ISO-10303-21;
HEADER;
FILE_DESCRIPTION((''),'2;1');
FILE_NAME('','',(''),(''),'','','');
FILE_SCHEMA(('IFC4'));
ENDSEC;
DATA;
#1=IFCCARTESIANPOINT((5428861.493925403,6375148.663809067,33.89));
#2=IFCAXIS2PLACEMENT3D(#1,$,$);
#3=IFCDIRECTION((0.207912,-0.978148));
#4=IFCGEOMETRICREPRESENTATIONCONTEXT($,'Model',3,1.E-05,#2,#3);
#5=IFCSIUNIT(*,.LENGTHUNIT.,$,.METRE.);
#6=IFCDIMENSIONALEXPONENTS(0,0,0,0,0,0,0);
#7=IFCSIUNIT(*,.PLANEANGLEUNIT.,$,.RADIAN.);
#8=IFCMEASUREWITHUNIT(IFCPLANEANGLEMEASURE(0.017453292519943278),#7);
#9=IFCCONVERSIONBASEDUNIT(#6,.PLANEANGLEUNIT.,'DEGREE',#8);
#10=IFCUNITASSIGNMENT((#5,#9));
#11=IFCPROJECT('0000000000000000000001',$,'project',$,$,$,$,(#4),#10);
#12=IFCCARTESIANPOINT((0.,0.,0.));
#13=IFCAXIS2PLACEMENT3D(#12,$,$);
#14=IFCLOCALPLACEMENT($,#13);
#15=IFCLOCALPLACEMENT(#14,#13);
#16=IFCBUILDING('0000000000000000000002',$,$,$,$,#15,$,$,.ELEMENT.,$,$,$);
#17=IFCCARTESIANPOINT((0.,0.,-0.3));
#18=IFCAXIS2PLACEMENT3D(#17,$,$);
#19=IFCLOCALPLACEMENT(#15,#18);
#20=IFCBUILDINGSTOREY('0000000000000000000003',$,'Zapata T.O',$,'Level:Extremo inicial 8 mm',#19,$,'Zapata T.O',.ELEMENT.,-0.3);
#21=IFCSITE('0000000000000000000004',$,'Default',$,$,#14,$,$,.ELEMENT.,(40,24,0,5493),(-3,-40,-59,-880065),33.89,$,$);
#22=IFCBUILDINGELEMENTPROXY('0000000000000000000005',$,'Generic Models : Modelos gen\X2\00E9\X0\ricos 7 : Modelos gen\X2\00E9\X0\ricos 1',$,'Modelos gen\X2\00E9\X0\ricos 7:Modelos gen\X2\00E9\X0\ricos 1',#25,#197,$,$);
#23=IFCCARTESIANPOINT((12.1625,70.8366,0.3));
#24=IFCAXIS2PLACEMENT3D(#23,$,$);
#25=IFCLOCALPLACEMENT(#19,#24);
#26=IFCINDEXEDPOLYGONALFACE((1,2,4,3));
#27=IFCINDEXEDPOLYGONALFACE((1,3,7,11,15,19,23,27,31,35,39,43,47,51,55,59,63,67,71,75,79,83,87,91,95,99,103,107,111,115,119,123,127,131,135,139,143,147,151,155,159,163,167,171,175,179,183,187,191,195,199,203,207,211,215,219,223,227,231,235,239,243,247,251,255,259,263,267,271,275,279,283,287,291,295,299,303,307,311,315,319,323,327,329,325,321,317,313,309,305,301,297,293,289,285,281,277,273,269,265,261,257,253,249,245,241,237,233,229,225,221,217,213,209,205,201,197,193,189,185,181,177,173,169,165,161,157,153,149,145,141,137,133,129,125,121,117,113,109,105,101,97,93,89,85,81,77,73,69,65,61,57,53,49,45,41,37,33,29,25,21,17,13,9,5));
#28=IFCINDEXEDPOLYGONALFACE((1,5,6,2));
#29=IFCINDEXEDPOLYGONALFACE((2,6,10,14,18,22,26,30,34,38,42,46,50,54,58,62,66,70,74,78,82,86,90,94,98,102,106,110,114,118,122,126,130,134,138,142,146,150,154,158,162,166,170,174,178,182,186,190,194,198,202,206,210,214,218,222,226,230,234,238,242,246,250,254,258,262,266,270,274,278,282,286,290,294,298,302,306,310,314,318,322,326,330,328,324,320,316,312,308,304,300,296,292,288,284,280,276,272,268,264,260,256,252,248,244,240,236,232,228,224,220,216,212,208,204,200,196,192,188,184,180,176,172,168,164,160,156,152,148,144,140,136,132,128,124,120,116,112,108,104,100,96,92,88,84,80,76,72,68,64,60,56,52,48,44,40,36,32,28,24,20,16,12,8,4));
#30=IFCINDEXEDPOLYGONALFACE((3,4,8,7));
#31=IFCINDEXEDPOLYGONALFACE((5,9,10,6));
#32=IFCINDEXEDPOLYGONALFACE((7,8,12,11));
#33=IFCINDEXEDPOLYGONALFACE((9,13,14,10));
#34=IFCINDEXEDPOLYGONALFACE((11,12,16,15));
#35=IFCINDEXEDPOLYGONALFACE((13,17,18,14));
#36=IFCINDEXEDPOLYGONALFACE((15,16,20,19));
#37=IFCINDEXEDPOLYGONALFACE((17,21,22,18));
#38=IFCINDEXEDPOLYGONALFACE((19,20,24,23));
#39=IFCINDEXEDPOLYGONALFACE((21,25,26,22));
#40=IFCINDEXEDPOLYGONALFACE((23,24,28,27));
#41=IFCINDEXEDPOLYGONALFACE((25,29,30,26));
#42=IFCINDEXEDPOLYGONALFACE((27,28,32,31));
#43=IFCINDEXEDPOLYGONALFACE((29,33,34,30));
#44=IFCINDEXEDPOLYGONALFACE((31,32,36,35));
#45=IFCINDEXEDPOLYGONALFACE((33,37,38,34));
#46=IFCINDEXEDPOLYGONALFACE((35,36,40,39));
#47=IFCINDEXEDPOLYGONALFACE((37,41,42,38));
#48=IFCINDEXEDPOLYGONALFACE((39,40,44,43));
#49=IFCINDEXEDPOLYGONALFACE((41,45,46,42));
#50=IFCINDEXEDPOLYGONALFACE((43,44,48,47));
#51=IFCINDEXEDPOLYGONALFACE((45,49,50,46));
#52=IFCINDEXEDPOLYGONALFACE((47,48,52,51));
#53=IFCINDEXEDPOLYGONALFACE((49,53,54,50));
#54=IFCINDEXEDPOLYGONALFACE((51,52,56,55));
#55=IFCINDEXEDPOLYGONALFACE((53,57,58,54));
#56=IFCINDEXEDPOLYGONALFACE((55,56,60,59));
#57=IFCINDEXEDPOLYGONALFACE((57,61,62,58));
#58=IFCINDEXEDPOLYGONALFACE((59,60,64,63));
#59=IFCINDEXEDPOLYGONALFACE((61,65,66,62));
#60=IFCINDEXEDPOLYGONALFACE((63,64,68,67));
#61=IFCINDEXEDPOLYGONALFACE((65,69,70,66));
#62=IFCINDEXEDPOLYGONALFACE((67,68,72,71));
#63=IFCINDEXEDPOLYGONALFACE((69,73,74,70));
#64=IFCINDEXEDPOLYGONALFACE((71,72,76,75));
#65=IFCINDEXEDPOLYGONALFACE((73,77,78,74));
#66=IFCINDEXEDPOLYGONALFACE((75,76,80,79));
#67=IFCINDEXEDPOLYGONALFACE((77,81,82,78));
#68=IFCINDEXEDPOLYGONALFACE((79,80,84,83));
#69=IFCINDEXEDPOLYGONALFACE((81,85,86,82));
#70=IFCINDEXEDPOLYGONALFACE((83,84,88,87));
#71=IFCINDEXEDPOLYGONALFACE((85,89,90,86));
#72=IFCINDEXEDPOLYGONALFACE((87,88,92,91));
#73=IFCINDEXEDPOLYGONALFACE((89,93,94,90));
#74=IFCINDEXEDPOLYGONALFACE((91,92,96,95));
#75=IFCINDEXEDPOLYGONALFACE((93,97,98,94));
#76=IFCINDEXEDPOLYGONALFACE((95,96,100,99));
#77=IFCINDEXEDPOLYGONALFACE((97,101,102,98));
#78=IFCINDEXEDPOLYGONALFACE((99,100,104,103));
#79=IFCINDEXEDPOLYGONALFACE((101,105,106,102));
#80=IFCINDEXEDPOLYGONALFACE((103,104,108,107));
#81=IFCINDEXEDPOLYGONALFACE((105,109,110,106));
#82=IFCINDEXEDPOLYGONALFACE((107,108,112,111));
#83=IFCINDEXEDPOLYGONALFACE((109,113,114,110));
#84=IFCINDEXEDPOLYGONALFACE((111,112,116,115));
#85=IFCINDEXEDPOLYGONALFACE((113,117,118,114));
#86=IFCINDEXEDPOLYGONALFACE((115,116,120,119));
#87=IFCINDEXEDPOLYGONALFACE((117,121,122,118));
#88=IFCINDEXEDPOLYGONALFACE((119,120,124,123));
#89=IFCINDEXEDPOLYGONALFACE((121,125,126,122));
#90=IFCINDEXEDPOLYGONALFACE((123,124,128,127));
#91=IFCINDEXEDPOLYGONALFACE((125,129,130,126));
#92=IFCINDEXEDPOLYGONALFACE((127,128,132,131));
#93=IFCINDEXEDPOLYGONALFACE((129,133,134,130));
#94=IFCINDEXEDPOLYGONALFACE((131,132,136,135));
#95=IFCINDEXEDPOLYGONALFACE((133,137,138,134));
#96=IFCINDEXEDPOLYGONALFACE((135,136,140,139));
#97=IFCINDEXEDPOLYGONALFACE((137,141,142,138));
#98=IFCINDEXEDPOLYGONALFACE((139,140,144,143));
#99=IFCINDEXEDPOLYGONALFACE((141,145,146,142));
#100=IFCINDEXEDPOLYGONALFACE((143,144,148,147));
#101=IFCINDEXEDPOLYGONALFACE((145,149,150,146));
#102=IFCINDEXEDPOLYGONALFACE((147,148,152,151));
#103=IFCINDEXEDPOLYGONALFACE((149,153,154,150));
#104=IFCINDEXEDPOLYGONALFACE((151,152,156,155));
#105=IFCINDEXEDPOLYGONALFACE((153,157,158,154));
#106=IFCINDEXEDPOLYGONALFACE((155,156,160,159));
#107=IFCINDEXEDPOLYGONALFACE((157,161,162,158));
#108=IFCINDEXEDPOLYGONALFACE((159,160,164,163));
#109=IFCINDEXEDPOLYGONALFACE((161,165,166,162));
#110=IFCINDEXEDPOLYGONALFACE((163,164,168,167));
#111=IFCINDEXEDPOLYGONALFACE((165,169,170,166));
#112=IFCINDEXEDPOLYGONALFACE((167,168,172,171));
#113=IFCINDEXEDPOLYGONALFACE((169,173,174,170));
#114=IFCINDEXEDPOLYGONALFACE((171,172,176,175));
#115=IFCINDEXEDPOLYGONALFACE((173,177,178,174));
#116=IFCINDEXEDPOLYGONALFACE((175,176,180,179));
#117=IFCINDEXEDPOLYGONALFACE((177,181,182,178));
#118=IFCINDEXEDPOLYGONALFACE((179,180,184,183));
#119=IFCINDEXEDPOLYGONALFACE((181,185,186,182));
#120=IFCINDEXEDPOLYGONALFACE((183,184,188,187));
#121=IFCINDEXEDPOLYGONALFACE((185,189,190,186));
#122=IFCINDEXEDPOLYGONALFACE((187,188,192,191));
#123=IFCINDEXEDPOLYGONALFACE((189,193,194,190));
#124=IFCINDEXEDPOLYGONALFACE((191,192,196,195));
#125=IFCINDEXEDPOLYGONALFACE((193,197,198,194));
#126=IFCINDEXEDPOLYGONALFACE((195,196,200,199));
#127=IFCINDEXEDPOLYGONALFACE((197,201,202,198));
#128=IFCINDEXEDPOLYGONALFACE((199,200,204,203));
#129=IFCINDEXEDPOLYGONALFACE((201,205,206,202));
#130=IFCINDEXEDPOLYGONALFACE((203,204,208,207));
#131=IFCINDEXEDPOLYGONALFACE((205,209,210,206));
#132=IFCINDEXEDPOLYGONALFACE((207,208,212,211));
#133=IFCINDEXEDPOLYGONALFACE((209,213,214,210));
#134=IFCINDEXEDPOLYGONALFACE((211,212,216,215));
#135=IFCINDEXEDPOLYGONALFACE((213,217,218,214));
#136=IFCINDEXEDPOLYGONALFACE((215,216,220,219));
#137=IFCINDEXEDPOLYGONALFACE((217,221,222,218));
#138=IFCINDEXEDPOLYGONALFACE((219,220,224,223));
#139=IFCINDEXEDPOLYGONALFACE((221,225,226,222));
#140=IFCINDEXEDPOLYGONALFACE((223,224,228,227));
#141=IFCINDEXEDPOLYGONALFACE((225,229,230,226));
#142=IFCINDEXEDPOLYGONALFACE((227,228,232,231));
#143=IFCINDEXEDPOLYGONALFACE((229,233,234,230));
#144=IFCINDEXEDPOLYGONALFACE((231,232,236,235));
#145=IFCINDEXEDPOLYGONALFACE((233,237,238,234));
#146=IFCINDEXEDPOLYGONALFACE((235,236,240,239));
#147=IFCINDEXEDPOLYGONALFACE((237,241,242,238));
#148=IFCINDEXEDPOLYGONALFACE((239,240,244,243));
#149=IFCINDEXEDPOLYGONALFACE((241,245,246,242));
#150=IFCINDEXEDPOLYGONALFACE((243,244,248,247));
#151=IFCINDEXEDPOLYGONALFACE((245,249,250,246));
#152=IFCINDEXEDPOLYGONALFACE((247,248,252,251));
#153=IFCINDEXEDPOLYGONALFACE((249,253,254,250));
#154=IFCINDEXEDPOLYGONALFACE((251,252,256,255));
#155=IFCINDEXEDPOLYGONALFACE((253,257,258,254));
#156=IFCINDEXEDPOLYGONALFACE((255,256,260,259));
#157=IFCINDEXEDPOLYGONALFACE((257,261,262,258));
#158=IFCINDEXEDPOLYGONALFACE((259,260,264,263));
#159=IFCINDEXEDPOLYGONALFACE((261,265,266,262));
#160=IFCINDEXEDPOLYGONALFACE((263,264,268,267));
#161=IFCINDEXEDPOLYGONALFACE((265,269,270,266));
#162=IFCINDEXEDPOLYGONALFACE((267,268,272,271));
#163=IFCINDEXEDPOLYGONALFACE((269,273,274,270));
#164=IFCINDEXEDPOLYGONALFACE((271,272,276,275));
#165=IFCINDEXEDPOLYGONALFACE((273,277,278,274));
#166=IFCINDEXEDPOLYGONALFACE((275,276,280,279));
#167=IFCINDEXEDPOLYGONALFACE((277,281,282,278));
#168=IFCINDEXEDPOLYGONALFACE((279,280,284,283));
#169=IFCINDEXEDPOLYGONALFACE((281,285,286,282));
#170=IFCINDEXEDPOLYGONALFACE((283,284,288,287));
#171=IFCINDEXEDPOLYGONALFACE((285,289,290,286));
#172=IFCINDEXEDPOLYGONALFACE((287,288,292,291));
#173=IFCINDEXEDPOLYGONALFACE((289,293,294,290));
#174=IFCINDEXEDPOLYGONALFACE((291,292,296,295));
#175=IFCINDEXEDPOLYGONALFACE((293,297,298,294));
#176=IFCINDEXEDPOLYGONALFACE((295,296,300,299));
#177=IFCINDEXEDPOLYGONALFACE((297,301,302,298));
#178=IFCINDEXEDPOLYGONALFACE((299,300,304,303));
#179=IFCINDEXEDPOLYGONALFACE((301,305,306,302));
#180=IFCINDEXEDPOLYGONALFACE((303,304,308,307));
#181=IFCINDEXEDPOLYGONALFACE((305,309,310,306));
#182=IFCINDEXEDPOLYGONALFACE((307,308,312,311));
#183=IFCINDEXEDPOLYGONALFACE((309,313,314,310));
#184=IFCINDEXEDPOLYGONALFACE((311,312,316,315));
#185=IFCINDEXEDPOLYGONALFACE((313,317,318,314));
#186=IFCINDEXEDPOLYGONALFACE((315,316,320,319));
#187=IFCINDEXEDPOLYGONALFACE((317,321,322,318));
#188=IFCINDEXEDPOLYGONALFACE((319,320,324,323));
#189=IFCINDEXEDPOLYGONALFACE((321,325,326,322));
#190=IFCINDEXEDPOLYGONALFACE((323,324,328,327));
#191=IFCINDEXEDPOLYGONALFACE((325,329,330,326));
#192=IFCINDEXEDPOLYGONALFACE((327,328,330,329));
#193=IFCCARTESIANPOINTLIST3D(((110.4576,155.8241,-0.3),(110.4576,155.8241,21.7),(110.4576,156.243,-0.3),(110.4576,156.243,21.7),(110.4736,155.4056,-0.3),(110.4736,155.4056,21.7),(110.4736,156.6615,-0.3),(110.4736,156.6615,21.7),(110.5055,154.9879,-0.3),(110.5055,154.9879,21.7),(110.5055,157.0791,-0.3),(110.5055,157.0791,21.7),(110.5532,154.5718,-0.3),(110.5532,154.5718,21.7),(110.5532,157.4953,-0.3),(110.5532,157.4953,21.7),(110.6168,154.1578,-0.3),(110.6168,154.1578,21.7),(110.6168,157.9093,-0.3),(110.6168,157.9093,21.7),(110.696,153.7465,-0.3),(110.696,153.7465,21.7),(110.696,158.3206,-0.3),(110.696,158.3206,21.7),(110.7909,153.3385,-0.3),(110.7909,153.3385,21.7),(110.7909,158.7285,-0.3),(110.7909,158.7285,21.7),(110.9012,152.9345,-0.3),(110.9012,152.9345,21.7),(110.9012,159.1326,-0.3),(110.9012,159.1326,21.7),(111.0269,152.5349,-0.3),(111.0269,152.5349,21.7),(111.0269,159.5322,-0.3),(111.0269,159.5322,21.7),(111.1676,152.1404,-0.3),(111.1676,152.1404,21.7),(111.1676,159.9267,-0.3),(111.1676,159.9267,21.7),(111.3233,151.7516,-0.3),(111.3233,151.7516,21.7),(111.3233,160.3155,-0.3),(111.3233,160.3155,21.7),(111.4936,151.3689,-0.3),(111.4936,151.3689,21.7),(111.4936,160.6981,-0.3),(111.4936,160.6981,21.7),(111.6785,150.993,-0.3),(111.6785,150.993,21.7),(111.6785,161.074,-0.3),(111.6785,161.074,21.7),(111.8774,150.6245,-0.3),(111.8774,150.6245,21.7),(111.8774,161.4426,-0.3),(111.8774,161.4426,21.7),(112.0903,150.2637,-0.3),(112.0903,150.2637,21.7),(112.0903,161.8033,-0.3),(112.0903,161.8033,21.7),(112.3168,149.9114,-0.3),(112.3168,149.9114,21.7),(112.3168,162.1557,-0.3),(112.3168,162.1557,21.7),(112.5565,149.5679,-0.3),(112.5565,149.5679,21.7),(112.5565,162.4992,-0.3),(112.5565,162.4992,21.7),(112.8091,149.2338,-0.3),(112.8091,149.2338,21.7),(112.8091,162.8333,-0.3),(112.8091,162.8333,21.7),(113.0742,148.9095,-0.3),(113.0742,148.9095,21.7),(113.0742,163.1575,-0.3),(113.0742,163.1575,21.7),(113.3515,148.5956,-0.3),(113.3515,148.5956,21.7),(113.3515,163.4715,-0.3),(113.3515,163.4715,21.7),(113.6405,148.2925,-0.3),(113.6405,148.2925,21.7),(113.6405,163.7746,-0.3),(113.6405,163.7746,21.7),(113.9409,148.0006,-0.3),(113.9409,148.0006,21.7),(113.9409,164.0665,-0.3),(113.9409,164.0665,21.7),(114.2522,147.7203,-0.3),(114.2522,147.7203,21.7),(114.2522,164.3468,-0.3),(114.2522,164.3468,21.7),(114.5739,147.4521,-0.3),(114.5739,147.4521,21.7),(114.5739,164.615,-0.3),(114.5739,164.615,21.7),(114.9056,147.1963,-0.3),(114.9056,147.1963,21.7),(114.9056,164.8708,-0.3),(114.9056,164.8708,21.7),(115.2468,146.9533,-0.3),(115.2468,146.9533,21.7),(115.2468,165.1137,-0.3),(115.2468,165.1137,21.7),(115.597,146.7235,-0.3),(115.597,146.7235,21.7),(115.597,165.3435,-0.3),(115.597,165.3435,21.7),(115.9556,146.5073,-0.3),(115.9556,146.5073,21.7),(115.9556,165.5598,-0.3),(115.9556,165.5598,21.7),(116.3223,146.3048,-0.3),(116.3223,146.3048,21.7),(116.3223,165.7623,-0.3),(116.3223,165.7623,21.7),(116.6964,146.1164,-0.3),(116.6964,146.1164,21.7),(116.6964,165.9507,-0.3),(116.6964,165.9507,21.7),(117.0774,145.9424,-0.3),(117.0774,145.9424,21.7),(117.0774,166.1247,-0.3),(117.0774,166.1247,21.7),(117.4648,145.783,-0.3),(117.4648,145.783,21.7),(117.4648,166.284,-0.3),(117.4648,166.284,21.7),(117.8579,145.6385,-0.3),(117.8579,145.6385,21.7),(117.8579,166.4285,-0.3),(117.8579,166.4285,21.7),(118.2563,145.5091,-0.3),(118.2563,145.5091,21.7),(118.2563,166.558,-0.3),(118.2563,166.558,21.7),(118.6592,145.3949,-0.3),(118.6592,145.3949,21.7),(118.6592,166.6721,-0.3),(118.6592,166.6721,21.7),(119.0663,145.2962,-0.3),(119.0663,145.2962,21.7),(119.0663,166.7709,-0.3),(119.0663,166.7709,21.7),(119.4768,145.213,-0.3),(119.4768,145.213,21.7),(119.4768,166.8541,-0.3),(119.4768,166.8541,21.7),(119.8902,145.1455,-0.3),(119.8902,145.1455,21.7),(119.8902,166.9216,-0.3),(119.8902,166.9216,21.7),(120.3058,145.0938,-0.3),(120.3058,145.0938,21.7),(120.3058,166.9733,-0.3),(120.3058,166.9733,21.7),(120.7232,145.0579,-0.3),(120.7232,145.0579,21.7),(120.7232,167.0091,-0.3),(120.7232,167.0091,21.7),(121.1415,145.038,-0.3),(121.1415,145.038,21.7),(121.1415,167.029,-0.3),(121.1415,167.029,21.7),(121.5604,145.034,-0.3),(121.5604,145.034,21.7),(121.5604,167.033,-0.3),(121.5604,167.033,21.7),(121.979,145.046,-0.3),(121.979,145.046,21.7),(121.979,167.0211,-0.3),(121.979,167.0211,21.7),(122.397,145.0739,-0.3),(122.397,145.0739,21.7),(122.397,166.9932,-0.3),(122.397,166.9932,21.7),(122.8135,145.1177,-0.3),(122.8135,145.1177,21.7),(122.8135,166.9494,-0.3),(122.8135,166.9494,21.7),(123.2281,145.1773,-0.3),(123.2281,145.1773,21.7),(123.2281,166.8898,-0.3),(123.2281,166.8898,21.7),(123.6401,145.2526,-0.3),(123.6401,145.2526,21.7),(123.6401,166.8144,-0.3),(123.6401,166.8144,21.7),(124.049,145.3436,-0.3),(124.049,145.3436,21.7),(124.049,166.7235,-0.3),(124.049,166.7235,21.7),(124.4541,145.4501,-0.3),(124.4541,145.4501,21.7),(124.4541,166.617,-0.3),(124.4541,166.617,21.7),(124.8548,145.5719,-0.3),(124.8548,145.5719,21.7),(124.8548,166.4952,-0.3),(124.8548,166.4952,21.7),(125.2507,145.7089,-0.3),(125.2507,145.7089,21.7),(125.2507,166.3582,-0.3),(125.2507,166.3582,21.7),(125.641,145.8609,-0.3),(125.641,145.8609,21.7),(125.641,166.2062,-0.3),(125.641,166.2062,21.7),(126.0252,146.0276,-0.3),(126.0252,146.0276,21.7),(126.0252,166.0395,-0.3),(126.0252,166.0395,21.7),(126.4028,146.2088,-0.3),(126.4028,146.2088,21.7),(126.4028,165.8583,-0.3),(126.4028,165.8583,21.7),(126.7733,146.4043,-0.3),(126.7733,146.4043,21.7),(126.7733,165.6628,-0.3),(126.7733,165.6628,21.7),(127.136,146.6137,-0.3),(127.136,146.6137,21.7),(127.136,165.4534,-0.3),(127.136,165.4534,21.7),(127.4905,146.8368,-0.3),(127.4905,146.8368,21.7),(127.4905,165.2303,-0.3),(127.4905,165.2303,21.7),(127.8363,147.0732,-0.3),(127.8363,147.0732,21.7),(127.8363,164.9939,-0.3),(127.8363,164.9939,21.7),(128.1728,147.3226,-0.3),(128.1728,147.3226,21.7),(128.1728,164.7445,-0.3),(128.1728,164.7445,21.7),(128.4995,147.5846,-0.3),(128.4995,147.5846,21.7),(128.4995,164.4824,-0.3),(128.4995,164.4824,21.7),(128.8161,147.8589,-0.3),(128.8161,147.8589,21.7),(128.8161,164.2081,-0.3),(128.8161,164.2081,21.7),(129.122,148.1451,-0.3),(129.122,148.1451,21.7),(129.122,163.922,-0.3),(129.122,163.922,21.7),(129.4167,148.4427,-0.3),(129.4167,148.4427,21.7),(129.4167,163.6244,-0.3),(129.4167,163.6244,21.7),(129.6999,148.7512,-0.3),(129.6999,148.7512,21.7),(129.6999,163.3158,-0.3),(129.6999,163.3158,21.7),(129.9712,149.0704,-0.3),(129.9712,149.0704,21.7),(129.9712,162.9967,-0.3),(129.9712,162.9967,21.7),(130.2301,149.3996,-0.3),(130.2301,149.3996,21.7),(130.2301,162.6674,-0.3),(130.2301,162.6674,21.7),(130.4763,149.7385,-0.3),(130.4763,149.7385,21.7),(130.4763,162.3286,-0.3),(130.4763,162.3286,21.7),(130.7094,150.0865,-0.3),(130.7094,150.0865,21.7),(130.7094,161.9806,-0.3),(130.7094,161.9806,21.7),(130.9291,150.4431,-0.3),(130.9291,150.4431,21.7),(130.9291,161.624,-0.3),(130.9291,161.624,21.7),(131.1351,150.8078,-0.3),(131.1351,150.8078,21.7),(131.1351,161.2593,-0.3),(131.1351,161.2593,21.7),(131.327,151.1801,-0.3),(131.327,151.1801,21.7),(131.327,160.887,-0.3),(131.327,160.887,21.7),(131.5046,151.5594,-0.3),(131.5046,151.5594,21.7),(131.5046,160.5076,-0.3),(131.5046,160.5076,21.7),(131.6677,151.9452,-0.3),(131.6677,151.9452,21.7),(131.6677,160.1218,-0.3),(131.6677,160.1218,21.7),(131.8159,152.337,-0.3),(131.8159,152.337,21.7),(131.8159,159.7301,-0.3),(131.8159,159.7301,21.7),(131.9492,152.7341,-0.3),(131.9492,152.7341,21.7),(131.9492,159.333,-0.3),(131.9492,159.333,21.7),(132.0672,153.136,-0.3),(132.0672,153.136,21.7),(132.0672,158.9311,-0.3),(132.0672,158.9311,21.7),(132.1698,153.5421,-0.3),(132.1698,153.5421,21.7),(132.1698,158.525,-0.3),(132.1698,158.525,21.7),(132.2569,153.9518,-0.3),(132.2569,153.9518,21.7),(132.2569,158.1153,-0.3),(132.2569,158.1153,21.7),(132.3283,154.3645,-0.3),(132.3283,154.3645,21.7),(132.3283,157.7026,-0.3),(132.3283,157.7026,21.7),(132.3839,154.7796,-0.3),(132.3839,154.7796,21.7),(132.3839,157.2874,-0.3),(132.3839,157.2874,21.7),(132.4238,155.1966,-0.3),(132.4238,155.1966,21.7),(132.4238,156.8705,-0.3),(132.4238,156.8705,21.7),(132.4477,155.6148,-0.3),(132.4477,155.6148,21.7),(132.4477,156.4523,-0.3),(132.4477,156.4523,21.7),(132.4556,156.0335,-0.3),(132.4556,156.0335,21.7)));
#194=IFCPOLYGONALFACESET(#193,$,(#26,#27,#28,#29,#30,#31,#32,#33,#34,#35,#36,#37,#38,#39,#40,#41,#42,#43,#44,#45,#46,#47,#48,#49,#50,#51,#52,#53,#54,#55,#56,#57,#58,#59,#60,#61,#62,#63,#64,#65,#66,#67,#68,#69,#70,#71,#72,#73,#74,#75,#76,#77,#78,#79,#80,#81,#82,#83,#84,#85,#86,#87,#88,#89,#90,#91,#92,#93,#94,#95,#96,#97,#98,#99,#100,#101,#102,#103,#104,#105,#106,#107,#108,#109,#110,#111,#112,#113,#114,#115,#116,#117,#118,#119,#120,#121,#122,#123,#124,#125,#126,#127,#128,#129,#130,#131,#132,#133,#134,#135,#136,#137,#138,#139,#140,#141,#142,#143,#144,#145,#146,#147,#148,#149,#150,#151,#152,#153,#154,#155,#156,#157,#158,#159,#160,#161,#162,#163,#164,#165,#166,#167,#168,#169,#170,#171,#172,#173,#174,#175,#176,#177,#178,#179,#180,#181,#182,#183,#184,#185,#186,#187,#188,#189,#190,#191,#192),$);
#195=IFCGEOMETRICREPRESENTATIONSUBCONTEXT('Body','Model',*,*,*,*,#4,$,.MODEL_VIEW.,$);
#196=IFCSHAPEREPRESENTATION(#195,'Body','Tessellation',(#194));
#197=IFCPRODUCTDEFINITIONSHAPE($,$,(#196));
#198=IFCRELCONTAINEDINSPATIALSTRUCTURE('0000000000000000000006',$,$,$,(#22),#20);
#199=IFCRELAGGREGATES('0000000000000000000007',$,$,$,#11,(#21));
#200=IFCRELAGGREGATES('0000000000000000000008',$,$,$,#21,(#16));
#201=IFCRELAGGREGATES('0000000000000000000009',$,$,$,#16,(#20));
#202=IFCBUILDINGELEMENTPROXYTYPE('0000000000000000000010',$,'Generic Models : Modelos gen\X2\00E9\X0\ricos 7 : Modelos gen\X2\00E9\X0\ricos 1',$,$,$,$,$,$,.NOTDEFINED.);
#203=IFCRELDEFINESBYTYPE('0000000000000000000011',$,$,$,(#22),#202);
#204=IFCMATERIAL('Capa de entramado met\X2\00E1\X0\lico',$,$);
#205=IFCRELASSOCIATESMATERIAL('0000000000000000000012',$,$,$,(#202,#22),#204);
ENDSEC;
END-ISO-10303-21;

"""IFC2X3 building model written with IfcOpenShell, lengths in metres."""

from ifc_helpers import new_model, entity, si_unit, converted_unit, direction, frame, frame_2d, origin, place, context, subcontext, project, spatial, circle, extrude, source, transform, mapped, material, type_object, type_shapes, element, save


model = new_model("IFC2X3")

# Units and contexts
model_context = context("Model", 3, precision=1e-05, world=frame((5428861.493925403, 6375148.663809067, 33.89)), true_north=direction((0.207912, -0.978148)))
body_context = subcontext(model_context, "Body", "Model", "MODEL_VIEW")
ifc_project = project(units=[si_unit("LENGTHUNIT", "METRE"), converted_unit("PLANEANGLEUNIT", "DEGREE", entity("IfcPlaneAngleMeasure", 0.017453292519943278), si_unit("PLANEANGLEUNIT", "RADIAN"), dimensions=[0, 0, 0, 0, 0, 0, 0])], contexts=[model_context])

# Site, building, storey
site_placement = place(None, origin())
site = spatial("IfcSite", under=ifc_project, at=site_placement, Name="Default", CompositionType="ELEMENT", RefLatitude=(40, 24, 0, 5493), RefLongitude=(-3, -40, -59, -880065), RefElevation=33.89)
building_placement = place(site_placement, origin())
building = spatial("IfcBuilding", under=site, at=building_placement, CompositionType="ELEMENT")
storey_placement = place(building_placement, frame((0.0, 0.0, -0.3)))
storey = spatial("IfcBuildingStorey", under=building, at=storey_placement, Name="Zapata T.O", ObjectType="Level:Extremo inicial 8 mm", LongName="Zapata T.O", CompositionType="ELEMENT", Elevation=-0.3)

# Building element proxy
ifc_material = material(Name="Capa de entramado metálico")
building_element_proxy_type_1 = type_object("IfcBuildingElementProxyType", Name="Generic Models : Modelos genéricos 7 : Modelos genéricos 1", PredefinedType="NOTDEFINED", material=ifc_material)
shared_shape_1 = source(origin(), body_context, "Body", "SweptSolid", [
    extrude(circle(Radius=11.0, at=frame_2d((0.0, 0.0), x_axis=(1.0, 0.0))), frame((121.4556, 156.0335, -0.3)), (0.0, 0.0, 1.0), 22.0),
])
type_shapes(building_element_proxy_type_1, [shared_shape_1])
proxy_1_placement = place(storey_placement, frame((12.1625, 70.8366, 0.3)))
element("IfcBuildingElementProxy", 1, at=proxy_1_placement, inside=storey, type_object=building_element_proxy_type_1, material=ifc_material, Name="Generic Models : Modelos genéricos 7 : Modelos genéricos 1", ObjectType="Modelos genéricos 7:Modelos genéricos 1", context=body_context, shape_type="MappedRepresentation", body=[
    mapped(shared_shape_1, transform((0.0, 0.0, 0.0), scale=1.0)),
])

save(model, "model.ifc")
